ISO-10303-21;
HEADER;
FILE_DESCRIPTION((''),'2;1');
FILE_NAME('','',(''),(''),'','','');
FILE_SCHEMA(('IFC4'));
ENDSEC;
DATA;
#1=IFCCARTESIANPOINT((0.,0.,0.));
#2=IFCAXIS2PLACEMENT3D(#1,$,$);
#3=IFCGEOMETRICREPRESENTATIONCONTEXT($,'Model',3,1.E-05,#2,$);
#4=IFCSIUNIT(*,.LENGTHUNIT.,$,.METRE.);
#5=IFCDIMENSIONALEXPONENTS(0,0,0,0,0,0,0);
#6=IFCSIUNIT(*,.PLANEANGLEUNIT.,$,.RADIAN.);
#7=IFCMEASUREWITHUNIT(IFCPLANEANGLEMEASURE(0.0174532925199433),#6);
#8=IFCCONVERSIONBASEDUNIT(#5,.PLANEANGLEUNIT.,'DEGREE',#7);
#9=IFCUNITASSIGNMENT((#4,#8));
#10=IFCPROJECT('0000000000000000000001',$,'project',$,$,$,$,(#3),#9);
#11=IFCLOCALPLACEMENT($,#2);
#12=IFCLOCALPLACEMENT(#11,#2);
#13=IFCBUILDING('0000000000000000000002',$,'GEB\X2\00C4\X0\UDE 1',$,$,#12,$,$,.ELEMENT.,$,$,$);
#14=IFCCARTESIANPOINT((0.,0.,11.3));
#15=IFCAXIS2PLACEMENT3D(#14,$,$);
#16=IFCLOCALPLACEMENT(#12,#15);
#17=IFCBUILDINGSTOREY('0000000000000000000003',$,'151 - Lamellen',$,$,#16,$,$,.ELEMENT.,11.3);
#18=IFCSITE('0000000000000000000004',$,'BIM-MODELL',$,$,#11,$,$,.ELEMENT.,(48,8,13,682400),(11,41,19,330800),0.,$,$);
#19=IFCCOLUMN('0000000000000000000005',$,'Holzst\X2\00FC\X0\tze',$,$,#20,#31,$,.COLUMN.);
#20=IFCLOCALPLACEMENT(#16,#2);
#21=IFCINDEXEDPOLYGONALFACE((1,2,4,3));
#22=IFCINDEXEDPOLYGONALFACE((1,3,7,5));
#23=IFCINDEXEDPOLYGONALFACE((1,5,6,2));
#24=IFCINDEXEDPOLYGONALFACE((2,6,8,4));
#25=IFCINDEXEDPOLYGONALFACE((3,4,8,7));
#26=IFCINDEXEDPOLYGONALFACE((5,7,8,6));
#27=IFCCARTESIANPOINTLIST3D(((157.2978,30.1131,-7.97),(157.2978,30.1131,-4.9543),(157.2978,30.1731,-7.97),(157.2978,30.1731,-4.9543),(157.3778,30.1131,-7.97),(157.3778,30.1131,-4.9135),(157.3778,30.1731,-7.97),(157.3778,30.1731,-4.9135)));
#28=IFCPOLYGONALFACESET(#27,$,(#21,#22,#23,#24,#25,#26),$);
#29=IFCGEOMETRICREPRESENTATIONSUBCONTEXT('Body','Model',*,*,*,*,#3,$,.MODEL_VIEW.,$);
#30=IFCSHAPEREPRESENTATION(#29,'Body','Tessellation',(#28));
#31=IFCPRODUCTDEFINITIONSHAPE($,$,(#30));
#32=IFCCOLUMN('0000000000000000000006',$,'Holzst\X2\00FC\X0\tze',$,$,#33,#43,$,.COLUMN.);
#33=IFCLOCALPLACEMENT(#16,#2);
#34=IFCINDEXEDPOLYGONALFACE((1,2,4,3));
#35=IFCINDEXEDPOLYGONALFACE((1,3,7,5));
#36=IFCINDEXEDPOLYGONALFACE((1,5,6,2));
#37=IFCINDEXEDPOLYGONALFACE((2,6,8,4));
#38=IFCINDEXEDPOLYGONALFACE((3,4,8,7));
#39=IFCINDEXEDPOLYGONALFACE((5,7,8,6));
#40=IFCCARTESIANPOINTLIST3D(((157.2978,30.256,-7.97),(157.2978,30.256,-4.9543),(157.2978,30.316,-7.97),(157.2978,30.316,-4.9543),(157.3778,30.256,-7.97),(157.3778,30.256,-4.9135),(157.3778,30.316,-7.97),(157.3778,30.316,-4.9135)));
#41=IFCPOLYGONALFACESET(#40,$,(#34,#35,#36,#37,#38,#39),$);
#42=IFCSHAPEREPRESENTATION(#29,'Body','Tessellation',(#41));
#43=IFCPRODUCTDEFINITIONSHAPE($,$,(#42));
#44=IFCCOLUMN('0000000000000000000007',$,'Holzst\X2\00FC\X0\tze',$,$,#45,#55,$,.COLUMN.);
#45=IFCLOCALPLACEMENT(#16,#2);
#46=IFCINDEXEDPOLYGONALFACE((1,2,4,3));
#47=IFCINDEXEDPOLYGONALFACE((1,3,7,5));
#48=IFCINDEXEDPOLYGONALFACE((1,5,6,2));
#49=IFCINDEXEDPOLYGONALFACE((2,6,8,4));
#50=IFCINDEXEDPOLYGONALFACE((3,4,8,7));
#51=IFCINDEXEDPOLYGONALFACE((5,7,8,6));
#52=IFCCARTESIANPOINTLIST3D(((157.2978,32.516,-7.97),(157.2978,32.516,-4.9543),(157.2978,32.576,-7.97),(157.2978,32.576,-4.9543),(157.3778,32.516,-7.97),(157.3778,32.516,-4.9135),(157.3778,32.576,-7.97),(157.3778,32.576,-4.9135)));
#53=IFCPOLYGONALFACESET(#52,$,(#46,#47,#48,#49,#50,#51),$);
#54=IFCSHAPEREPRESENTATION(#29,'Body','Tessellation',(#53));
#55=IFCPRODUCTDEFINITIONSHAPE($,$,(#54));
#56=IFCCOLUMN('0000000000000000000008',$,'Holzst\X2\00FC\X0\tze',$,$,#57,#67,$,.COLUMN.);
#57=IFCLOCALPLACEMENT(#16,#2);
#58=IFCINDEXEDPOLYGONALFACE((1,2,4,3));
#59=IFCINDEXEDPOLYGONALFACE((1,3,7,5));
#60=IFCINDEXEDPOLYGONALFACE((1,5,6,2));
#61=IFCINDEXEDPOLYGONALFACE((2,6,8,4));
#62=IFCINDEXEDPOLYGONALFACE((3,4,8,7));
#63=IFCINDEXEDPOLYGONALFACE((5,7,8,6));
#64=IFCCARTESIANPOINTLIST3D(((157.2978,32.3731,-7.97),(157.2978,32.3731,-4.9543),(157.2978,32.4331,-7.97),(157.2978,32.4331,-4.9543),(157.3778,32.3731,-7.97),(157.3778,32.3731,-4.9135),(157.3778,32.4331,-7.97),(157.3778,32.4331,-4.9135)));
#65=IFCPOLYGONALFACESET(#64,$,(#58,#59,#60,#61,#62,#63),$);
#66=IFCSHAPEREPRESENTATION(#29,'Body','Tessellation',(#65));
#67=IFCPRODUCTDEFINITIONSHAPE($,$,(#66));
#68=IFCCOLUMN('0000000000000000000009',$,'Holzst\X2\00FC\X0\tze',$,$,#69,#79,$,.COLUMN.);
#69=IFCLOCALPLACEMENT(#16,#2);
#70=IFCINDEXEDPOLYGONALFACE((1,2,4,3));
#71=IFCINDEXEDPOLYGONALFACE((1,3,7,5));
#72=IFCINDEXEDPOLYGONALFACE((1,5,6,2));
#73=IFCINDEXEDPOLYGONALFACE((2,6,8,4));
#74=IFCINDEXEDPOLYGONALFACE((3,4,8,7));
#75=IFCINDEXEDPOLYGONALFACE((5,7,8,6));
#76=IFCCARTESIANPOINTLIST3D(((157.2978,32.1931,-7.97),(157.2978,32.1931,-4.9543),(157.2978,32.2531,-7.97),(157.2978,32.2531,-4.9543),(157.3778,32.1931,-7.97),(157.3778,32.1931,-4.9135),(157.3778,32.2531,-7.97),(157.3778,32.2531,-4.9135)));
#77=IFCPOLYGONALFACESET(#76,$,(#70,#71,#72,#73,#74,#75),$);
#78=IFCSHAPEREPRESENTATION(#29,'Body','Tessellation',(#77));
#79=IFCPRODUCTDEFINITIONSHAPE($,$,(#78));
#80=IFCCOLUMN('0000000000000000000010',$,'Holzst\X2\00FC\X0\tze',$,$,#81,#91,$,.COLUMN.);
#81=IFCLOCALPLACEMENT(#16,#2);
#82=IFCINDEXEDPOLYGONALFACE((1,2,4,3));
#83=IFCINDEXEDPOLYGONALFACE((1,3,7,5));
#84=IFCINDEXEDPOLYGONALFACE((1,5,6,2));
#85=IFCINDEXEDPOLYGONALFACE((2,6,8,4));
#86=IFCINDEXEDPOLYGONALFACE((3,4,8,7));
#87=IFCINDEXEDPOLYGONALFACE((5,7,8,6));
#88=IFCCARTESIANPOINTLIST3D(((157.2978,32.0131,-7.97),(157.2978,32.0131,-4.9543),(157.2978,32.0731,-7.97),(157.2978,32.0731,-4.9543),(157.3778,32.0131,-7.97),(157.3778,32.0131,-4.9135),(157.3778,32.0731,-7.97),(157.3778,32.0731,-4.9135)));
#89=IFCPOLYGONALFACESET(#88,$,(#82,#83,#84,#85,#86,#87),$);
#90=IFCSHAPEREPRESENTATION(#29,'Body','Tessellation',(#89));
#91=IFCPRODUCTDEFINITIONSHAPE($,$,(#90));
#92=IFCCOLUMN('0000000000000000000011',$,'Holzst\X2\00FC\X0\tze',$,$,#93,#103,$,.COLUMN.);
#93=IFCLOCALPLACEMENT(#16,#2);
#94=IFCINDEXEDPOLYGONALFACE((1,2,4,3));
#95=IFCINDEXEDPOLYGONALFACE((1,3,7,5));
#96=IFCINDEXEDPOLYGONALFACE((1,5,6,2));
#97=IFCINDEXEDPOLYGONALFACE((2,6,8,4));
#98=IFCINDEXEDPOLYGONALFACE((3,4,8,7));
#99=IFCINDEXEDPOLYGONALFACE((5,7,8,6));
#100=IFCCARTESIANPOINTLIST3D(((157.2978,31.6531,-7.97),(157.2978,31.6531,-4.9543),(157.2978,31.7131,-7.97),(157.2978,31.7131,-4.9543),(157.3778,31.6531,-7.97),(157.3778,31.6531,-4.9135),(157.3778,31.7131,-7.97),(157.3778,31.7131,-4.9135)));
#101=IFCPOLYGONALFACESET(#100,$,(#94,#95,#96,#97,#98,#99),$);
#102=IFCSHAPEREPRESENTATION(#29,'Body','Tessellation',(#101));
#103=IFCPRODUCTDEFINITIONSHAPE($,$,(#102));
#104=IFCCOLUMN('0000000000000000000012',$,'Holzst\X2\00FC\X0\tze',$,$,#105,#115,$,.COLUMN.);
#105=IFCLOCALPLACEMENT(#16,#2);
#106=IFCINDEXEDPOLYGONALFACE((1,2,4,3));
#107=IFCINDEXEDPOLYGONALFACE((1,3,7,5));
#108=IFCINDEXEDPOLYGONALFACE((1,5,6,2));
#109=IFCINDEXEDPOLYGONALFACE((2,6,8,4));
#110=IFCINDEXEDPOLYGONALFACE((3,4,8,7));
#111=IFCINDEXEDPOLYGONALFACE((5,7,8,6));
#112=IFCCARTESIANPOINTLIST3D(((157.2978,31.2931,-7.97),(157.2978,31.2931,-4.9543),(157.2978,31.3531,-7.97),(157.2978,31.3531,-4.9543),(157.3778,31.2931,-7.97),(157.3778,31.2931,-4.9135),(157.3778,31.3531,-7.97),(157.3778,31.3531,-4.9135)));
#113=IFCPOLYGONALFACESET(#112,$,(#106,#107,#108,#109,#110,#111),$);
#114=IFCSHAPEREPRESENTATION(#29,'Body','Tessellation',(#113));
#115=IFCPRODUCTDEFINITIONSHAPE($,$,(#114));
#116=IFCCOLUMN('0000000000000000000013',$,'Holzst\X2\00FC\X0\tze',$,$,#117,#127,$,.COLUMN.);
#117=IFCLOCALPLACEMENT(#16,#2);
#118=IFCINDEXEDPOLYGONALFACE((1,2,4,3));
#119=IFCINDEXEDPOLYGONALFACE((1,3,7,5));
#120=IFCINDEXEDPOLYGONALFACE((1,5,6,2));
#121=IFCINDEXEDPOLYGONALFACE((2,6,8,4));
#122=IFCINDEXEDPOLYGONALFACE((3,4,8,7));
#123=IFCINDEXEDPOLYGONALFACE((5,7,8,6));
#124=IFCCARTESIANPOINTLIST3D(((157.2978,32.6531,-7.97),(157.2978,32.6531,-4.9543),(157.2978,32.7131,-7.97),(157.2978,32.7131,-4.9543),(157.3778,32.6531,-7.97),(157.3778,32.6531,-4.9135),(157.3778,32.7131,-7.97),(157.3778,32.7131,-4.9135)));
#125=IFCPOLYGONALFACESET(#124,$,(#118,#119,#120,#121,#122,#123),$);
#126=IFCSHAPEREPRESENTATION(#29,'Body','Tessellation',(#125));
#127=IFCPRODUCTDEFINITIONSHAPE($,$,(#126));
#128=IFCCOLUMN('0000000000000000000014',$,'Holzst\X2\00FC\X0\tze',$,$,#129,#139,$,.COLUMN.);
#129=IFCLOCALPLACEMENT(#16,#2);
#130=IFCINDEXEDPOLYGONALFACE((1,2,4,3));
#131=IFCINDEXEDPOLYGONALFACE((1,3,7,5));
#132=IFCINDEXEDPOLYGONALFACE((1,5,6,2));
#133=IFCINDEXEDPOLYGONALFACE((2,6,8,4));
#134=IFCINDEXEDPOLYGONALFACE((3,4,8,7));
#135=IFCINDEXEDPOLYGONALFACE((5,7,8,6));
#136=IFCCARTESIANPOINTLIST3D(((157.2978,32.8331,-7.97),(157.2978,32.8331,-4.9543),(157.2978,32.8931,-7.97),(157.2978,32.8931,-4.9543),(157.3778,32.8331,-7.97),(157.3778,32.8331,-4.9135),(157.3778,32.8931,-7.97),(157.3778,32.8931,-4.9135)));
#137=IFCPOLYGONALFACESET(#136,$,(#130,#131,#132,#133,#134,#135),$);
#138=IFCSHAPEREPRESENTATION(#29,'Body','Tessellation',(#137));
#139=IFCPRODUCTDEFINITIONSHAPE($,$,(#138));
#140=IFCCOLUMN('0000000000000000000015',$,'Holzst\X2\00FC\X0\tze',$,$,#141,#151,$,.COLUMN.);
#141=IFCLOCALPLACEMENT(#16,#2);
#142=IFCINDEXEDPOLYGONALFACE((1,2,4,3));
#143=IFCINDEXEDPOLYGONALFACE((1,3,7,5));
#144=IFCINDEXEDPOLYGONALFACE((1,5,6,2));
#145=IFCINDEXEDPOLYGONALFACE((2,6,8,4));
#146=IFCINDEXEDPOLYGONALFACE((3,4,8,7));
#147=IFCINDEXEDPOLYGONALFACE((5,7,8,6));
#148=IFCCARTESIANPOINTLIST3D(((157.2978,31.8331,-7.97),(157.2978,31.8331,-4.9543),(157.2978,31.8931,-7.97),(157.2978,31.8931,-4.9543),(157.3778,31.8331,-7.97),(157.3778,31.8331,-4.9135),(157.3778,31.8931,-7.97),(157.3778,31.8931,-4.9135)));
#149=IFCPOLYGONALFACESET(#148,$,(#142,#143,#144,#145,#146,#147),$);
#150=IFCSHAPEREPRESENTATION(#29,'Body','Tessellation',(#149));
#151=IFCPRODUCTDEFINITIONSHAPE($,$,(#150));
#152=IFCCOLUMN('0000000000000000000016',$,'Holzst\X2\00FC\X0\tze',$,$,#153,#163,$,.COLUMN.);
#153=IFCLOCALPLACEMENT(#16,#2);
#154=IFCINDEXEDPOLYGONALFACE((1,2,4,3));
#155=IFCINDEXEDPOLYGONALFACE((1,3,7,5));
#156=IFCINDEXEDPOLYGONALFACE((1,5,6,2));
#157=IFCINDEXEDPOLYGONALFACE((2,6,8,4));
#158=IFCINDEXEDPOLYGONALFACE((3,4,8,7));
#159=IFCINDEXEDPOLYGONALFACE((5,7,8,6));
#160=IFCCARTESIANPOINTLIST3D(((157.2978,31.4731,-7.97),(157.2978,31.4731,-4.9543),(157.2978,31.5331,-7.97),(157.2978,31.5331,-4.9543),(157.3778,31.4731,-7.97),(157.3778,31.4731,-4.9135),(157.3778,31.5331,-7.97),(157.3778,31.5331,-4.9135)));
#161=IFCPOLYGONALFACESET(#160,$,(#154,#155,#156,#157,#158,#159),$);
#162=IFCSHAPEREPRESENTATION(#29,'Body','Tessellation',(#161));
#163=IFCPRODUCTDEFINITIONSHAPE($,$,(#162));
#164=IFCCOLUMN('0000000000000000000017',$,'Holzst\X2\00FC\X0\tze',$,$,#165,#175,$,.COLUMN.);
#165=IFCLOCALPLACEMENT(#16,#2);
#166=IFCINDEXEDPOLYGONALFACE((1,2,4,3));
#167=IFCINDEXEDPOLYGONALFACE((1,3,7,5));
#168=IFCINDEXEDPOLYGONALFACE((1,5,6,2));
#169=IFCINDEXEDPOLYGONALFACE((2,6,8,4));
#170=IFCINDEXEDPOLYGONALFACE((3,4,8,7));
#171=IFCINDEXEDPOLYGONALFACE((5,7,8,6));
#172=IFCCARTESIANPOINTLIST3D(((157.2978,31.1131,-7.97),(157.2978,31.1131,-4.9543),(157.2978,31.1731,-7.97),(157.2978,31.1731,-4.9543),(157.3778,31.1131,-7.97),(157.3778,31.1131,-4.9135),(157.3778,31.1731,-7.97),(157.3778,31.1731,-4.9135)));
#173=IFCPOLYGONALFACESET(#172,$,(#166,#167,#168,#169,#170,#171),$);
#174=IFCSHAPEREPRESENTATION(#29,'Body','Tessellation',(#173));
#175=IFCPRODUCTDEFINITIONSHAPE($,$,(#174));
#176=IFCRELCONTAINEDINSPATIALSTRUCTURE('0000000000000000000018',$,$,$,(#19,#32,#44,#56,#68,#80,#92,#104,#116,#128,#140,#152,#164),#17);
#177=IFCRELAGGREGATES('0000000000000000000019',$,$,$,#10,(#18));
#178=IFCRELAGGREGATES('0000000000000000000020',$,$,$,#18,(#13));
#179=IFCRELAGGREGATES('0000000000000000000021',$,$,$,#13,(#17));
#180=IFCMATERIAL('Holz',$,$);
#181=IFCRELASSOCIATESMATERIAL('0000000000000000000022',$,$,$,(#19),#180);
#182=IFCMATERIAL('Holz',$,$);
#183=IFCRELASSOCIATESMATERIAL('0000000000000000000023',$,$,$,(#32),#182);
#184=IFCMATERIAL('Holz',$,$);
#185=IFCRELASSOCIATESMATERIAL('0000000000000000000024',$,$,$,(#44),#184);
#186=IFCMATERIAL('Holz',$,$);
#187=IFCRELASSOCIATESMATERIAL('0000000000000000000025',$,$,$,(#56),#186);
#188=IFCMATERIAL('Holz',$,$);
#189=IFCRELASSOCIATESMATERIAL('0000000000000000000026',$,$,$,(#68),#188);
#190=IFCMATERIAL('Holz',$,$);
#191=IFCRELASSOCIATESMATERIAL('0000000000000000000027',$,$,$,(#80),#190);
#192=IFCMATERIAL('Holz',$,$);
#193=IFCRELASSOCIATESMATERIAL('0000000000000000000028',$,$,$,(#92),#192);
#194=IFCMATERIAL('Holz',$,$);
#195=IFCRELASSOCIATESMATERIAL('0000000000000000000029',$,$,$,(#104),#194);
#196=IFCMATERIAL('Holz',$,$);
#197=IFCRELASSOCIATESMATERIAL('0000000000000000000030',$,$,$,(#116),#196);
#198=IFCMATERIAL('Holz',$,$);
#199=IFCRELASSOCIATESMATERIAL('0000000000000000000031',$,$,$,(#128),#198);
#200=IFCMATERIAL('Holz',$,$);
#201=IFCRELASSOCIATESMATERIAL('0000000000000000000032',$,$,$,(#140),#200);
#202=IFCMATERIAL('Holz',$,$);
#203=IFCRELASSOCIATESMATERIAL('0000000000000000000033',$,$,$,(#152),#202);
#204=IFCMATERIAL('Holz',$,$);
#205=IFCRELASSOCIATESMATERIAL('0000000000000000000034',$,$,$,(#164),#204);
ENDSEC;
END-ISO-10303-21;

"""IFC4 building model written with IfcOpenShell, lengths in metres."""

from ifc_helpers import new_model, entity, si_unit, converted_unit, frame, frame_2d, origin, origin_with_axes, place, context, subcontext, project, spatial, rectangle, extrude, clip, halfspace, material, element, save


model = new_model("IFC4")

# Units and contexts
model_context = context("Model", 3, precision=1e-05, world=origin())
body_context = subcontext(model_context, "Body", "Model", "MODEL_VIEW")
ifc_project = project(units=[si_unit("LENGTHUNIT", "METRE"), converted_unit("PLANEANGLEUNIT", "DEGREE", entity("IfcPlaneAngleMeasure", 0.0174532925199433), si_unit("PLANEANGLEUNIT", "RADIAN"), dimensions=[0, 0, 0, 0, 0, 0, 0])], contexts=[model_context])

# Site, building, storey
site_placement = place(None, origin())
site = spatial("IfcSite", under=ifc_project, at=site_placement, Name="BIM-MODELL", CompositionType="ELEMENT", RefLatitude=(48, 8, 13, 682400), RefLongitude=(11, 41, 19, 330800), RefElevation=0.0)
building_placement = place(site_placement, origin())
building = spatial("IfcBuilding", under=site, at=building_placement, Name="GEBÄUDE 1", CompositionType="ELEMENT")
storey_placement = place(building_placement, frame((0.0, 0.0, 11.3)))
storey = spatial("IfcBuildingStorey", under=building, at=storey_placement, Name="151 - Lamellen", CompositionType="ELEMENT", Elevation=11.3)

# Columns
ifc_material_1 = material(Name="Holz")
column_1_placement = place(storey_placement, frame((157.3778, 30.1131, -7.97)))
element("IfcColumn", 1, at=column_1_placement, inside=storey, material=ifc_material_1, Name="Holzstütze", PredefinedType="COLUMN", context=body_context, shape_type="Clipping", body=[
    clip(extrude(rectangle(XDim=0.06, YDim=0.08, at=frame_2d((-0.04, 0.03), x_axis=(0.0, 1.0))), origin_with_axes(), (0.0, 0.0, 1.0), 3.0565), halfspace(frame((-0.04, 0.03, 3.0361), z_axis=(0.45399, 0.0, -0.891007), x_axis=(-0.891007, 0.0, -0.45399)), True)),
])
ifc_material_2 = material(Name="Holz")
column_2_placement = place(storey_placement, frame((157.3778, 30.256, -7.97)))
element("IfcColumn", 2, at=column_2_placement, inside=storey, material=ifc_material_2, Name="Holzstütze", PredefinedType="COLUMN", context=body_context, shape_type="Clipping", body=[
    clip(extrude(rectangle(XDim=0.06, YDim=0.08, at=frame_2d((-0.04, 0.03), x_axis=(0.0, 1.0))), origin_with_axes(), (0.0, 0.0, 1.0), 3.0565), halfspace(frame((-0.04, 0.03, 3.0361), z_axis=(0.45399, 0.0, -0.891007), x_axis=(-0.891007, 0.0, -0.45399)), True)),
])
ifc_material_3 = material(Name="Holz")
column_3_placement = place(storey_placement, frame((157.3778, 32.516, -7.97)))
element("IfcColumn", 3, at=column_3_placement, inside=storey, material=ifc_material_3, Name="Holzstütze", PredefinedType="COLUMN", context=body_context, shape_type="Clipping", body=[
    clip(extrude(rectangle(XDim=0.06, YDim=0.08, at=frame_2d((-0.04, 0.03), x_axis=(0.0, 1.0))), origin_with_axes(), (0.0, 0.0, 1.0), 3.0565), halfspace(frame((-0.04, 0.03, 3.0361), z_axis=(0.45399, 0.0, -0.891007), x_axis=(-0.891007, 0.0, -0.45399)), True)),
])
ifc_material_4 = material(Name="Holz")
column_4_placement = place(storey_placement, frame((157.3778, 32.3731, -7.97)))
element("IfcColumn", 4, at=column_4_placement, inside=storey, material=ifc_material_4, Name="Holzstütze", PredefinedType="COLUMN", context=body_context, shape_type="Clipping", body=[
    clip(extrude(rectangle(XDim=0.06, YDim=0.08, at=frame_2d((-0.04, 0.03), x_axis=(0.0, 1.0))), origin_with_axes(), (0.0, 0.0, 1.0), 3.0565), halfspace(frame((-0.04, 0.03, 3.0361), z_axis=(0.45399, 0.0, -0.891007), x_axis=(-0.891007, 0.0, -0.45399)), True)),
])
ifc_material_5 = material(Name="Holz")
column_5_placement = place(storey_placement, frame((157.3778, 32.1931, -7.97)))
element("IfcColumn", 5, at=column_5_placement, inside=storey, material=ifc_material_5, Name="Holzstütze", PredefinedType="COLUMN", context=body_context, shape_type="Clipping", body=[
    clip(extrude(rectangle(XDim=0.06, YDim=0.08, at=frame_2d((-0.04, 0.03), x_axis=(0.0, 1.0))), origin_with_axes(), (0.0, 0.0, 1.0), 3.0565), halfspace(frame((-0.04, 0.03, 3.0361), z_axis=(0.45399, 0.0, -0.891007), x_axis=(-0.891007, 0.0, -0.45399)), True)),
])
ifc_material_6 = material(Name="Holz")
column_6_placement = place(storey_placement, frame((157.3778, 32.0131, -7.97)))
element("IfcColumn", 6, at=column_6_placement, inside=storey, material=ifc_material_6, Name="Holzstütze", PredefinedType="COLUMN", context=body_context, shape_type="Clipping", body=[
    clip(extrude(rectangle(XDim=0.06, YDim=0.08, at=frame_2d((-0.04, 0.03), x_axis=(0.0, 1.0))), origin_with_axes(), (0.0, 0.0, 1.0), 3.0565), halfspace(frame((-0.04, 0.03, 3.0361), z_axis=(0.45399, 0.0, -0.891007), x_axis=(-0.891007, 0.0, -0.45399)), True)),
])
ifc_material_7 = material(Name="Holz")
column_7_placement = place(storey_placement, frame((157.3778, 31.6531, -7.97)))
element("IfcColumn", 7, at=column_7_placement, inside=storey, material=ifc_material_7, Name="Holzstütze", PredefinedType="COLUMN", context=body_context, shape_type="Clipping", body=[
    clip(extrude(rectangle(XDim=0.06, YDim=0.08, at=frame_2d((-0.04, 0.03), x_axis=(0.0, 1.0))), origin_with_axes(), (0.0, 0.0, 1.0), 3.0565), halfspace(frame((-0.04, 0.03, 3.0361), z_axis=(0.45399, 0.0, -0.891007), x_axis=(-0.891007, 0.0, -0.45399)), True)),
])
ifc_material_8 = material(Name="Holz")
column_8_placement = place(storey_placement, frame((157.3778, 31.2931, -7.97)))
element("IfcColumn", 8, at=column_8_placement, inside=storey, material=ifc_material_8, Name="Holzstütze", PredefinedType="COLUMN", context=body_context, shape_type="Clipping", body=[
    clip(extrude(rectangle(XDim=0.06, YDim=0.08, at=frame_2d((-0.04, 0.03), x_axis=(0.0, 1.0))), origin_with_axes(), (0.0, 0.0, 1.0), 3.0565), halfspace(frame((-0.04, 0.03, 3.0361), z_axis=(0.45399, 0.0, -0.891007), x_axis=(-0.891007, 0.0, -0.45399)), True)),
])
ifc_material_9 = material(Name="Holz")
column_9_placement = place(storey_placement, frame((157.3778, 32.6531, -7.97)))
element("IfcColumn", 9, at=column_9_placement, inside=storey, material=ifc_material_9, Name="Holzstütze", PredefinedType="COLUMN", context=body_context, shape_type="Clipping", body=[
    clip(extrude(rectangle(XDim=0.06, YDim=0.08, at=frame_2d((-0.04, 0.03), x_axis=(0.0, 1.0))), origin_with_axes(), (0.0, 0.0, 1.0), 3.0565), halfspace(frame((-0.04, 0.03, 3.0361), z_axis=(0.45399, 0.0, -0.891007), x_axis=(-0.891007, 0.0, -0.45399)), True)),
])
ifc_material_10 = material(Name="Holz")
column_10_placement = place(storey_placement, frame((157.3778, 32.8331, -7.97)))
element("IfcColumn", 10, at=column_10_placement, inside=storey, material=ifc_material_10, Name="Holzstütze", PredefinedType="COLUMN", context=body_context, shape_type="Clipping", body=[
    clip(extrude(rectangle(XDim=0.06, YDim=0.08, at=frame_2d((-0.04, 0.03), x_axis=(0.0, 1.0))), origin_with_axes(), (0.0, 0.0, 1.0), 3.0565), halfspace(frame((-0.04, 0.03, 3.0361), z_axis=(0.45399, 0.0, -0.891007), x_axis=(-0.891007, 0.0, -0.45399)), True)),
])
ifc_material_11 = material(Name="Holz")
column_11_placement = place(storey_placement, frame((157.3778, 31.8331, -7.97)))
element("IfcColumn", 11, at=column_11_placement, inside=storey, material=ifc_material_11, Name="Holzstütze", PredefinedType="COLUMN", context=body_context, shape_type="Clipping", body=[
    clip(extrude(rectangle(XDim=0.06, YDim=0.08, at=frame_2d((-0.04, 0.03), x_axis=(0.0, 1.0))), origin_with_axes(), (0.0, 0.0, 1.0), 3.0565), halfspace(frame((-0.04, 0.03, 3.0361), z_axis=(0.45399, 0.0, -0.891007), x_axis=(-0.891007, 0.0, -0.45399)), True)),
])
ifc_material_12 = material(Name="Holz")
column_12_placement = place(storey_placement, frame((157.3778, 31.4731, -7.97)))
element("IfcColumn", 12, at=column_12_placement, inside=storey, material=ifc_material_12, Name="Holzstütze", PredefinedType="COLUMN", context=body_context, shape_type="Clipping", body=[
    clip(extrude(rectangle(XDim=0.06, YDim=0.08, at=frame_2d((-0.04, 0.03), x_axis=(0.0, 1.0))), origin_with_axes(), (0.0, 0.0, 1.0), 3.0565), halfspace(frame((-0.04, 0.03, 3.0361), z_axis=(0.45399, 0.0, -0.891007), x_axis=(-0.891007, 0.0, -0.45399)), True)),
])
ifc_material_13 = material(Name="Holz")
column_13_placement = place(storey_placement, frame((157.3778, 31.1131, -7.97)))
element("IfcColumn", 13, at=column_13_placement, inside=storey, material=ifc_material_13, Name="Holzstütze", PredefinedType="COLUMN", context=body_context, shape_type="Clipping", body=[
    clip(extrude(rectangle(XDim=0.06, YDim=0.08, at=frame_2d((-0.04, 0.03), x_axis=(0.0, 1.0))), origin_with_axes(), (0.0, 0.0, 1.0), 3.0565), halfspace(frame((-0.04, 0.03, 3.0361), z_axis=(0.45399, 0.0, -0.891007), x_axis=(-0.891007, 0.0, -0.45399)), True)),
])

save(model, "model.ifc")
